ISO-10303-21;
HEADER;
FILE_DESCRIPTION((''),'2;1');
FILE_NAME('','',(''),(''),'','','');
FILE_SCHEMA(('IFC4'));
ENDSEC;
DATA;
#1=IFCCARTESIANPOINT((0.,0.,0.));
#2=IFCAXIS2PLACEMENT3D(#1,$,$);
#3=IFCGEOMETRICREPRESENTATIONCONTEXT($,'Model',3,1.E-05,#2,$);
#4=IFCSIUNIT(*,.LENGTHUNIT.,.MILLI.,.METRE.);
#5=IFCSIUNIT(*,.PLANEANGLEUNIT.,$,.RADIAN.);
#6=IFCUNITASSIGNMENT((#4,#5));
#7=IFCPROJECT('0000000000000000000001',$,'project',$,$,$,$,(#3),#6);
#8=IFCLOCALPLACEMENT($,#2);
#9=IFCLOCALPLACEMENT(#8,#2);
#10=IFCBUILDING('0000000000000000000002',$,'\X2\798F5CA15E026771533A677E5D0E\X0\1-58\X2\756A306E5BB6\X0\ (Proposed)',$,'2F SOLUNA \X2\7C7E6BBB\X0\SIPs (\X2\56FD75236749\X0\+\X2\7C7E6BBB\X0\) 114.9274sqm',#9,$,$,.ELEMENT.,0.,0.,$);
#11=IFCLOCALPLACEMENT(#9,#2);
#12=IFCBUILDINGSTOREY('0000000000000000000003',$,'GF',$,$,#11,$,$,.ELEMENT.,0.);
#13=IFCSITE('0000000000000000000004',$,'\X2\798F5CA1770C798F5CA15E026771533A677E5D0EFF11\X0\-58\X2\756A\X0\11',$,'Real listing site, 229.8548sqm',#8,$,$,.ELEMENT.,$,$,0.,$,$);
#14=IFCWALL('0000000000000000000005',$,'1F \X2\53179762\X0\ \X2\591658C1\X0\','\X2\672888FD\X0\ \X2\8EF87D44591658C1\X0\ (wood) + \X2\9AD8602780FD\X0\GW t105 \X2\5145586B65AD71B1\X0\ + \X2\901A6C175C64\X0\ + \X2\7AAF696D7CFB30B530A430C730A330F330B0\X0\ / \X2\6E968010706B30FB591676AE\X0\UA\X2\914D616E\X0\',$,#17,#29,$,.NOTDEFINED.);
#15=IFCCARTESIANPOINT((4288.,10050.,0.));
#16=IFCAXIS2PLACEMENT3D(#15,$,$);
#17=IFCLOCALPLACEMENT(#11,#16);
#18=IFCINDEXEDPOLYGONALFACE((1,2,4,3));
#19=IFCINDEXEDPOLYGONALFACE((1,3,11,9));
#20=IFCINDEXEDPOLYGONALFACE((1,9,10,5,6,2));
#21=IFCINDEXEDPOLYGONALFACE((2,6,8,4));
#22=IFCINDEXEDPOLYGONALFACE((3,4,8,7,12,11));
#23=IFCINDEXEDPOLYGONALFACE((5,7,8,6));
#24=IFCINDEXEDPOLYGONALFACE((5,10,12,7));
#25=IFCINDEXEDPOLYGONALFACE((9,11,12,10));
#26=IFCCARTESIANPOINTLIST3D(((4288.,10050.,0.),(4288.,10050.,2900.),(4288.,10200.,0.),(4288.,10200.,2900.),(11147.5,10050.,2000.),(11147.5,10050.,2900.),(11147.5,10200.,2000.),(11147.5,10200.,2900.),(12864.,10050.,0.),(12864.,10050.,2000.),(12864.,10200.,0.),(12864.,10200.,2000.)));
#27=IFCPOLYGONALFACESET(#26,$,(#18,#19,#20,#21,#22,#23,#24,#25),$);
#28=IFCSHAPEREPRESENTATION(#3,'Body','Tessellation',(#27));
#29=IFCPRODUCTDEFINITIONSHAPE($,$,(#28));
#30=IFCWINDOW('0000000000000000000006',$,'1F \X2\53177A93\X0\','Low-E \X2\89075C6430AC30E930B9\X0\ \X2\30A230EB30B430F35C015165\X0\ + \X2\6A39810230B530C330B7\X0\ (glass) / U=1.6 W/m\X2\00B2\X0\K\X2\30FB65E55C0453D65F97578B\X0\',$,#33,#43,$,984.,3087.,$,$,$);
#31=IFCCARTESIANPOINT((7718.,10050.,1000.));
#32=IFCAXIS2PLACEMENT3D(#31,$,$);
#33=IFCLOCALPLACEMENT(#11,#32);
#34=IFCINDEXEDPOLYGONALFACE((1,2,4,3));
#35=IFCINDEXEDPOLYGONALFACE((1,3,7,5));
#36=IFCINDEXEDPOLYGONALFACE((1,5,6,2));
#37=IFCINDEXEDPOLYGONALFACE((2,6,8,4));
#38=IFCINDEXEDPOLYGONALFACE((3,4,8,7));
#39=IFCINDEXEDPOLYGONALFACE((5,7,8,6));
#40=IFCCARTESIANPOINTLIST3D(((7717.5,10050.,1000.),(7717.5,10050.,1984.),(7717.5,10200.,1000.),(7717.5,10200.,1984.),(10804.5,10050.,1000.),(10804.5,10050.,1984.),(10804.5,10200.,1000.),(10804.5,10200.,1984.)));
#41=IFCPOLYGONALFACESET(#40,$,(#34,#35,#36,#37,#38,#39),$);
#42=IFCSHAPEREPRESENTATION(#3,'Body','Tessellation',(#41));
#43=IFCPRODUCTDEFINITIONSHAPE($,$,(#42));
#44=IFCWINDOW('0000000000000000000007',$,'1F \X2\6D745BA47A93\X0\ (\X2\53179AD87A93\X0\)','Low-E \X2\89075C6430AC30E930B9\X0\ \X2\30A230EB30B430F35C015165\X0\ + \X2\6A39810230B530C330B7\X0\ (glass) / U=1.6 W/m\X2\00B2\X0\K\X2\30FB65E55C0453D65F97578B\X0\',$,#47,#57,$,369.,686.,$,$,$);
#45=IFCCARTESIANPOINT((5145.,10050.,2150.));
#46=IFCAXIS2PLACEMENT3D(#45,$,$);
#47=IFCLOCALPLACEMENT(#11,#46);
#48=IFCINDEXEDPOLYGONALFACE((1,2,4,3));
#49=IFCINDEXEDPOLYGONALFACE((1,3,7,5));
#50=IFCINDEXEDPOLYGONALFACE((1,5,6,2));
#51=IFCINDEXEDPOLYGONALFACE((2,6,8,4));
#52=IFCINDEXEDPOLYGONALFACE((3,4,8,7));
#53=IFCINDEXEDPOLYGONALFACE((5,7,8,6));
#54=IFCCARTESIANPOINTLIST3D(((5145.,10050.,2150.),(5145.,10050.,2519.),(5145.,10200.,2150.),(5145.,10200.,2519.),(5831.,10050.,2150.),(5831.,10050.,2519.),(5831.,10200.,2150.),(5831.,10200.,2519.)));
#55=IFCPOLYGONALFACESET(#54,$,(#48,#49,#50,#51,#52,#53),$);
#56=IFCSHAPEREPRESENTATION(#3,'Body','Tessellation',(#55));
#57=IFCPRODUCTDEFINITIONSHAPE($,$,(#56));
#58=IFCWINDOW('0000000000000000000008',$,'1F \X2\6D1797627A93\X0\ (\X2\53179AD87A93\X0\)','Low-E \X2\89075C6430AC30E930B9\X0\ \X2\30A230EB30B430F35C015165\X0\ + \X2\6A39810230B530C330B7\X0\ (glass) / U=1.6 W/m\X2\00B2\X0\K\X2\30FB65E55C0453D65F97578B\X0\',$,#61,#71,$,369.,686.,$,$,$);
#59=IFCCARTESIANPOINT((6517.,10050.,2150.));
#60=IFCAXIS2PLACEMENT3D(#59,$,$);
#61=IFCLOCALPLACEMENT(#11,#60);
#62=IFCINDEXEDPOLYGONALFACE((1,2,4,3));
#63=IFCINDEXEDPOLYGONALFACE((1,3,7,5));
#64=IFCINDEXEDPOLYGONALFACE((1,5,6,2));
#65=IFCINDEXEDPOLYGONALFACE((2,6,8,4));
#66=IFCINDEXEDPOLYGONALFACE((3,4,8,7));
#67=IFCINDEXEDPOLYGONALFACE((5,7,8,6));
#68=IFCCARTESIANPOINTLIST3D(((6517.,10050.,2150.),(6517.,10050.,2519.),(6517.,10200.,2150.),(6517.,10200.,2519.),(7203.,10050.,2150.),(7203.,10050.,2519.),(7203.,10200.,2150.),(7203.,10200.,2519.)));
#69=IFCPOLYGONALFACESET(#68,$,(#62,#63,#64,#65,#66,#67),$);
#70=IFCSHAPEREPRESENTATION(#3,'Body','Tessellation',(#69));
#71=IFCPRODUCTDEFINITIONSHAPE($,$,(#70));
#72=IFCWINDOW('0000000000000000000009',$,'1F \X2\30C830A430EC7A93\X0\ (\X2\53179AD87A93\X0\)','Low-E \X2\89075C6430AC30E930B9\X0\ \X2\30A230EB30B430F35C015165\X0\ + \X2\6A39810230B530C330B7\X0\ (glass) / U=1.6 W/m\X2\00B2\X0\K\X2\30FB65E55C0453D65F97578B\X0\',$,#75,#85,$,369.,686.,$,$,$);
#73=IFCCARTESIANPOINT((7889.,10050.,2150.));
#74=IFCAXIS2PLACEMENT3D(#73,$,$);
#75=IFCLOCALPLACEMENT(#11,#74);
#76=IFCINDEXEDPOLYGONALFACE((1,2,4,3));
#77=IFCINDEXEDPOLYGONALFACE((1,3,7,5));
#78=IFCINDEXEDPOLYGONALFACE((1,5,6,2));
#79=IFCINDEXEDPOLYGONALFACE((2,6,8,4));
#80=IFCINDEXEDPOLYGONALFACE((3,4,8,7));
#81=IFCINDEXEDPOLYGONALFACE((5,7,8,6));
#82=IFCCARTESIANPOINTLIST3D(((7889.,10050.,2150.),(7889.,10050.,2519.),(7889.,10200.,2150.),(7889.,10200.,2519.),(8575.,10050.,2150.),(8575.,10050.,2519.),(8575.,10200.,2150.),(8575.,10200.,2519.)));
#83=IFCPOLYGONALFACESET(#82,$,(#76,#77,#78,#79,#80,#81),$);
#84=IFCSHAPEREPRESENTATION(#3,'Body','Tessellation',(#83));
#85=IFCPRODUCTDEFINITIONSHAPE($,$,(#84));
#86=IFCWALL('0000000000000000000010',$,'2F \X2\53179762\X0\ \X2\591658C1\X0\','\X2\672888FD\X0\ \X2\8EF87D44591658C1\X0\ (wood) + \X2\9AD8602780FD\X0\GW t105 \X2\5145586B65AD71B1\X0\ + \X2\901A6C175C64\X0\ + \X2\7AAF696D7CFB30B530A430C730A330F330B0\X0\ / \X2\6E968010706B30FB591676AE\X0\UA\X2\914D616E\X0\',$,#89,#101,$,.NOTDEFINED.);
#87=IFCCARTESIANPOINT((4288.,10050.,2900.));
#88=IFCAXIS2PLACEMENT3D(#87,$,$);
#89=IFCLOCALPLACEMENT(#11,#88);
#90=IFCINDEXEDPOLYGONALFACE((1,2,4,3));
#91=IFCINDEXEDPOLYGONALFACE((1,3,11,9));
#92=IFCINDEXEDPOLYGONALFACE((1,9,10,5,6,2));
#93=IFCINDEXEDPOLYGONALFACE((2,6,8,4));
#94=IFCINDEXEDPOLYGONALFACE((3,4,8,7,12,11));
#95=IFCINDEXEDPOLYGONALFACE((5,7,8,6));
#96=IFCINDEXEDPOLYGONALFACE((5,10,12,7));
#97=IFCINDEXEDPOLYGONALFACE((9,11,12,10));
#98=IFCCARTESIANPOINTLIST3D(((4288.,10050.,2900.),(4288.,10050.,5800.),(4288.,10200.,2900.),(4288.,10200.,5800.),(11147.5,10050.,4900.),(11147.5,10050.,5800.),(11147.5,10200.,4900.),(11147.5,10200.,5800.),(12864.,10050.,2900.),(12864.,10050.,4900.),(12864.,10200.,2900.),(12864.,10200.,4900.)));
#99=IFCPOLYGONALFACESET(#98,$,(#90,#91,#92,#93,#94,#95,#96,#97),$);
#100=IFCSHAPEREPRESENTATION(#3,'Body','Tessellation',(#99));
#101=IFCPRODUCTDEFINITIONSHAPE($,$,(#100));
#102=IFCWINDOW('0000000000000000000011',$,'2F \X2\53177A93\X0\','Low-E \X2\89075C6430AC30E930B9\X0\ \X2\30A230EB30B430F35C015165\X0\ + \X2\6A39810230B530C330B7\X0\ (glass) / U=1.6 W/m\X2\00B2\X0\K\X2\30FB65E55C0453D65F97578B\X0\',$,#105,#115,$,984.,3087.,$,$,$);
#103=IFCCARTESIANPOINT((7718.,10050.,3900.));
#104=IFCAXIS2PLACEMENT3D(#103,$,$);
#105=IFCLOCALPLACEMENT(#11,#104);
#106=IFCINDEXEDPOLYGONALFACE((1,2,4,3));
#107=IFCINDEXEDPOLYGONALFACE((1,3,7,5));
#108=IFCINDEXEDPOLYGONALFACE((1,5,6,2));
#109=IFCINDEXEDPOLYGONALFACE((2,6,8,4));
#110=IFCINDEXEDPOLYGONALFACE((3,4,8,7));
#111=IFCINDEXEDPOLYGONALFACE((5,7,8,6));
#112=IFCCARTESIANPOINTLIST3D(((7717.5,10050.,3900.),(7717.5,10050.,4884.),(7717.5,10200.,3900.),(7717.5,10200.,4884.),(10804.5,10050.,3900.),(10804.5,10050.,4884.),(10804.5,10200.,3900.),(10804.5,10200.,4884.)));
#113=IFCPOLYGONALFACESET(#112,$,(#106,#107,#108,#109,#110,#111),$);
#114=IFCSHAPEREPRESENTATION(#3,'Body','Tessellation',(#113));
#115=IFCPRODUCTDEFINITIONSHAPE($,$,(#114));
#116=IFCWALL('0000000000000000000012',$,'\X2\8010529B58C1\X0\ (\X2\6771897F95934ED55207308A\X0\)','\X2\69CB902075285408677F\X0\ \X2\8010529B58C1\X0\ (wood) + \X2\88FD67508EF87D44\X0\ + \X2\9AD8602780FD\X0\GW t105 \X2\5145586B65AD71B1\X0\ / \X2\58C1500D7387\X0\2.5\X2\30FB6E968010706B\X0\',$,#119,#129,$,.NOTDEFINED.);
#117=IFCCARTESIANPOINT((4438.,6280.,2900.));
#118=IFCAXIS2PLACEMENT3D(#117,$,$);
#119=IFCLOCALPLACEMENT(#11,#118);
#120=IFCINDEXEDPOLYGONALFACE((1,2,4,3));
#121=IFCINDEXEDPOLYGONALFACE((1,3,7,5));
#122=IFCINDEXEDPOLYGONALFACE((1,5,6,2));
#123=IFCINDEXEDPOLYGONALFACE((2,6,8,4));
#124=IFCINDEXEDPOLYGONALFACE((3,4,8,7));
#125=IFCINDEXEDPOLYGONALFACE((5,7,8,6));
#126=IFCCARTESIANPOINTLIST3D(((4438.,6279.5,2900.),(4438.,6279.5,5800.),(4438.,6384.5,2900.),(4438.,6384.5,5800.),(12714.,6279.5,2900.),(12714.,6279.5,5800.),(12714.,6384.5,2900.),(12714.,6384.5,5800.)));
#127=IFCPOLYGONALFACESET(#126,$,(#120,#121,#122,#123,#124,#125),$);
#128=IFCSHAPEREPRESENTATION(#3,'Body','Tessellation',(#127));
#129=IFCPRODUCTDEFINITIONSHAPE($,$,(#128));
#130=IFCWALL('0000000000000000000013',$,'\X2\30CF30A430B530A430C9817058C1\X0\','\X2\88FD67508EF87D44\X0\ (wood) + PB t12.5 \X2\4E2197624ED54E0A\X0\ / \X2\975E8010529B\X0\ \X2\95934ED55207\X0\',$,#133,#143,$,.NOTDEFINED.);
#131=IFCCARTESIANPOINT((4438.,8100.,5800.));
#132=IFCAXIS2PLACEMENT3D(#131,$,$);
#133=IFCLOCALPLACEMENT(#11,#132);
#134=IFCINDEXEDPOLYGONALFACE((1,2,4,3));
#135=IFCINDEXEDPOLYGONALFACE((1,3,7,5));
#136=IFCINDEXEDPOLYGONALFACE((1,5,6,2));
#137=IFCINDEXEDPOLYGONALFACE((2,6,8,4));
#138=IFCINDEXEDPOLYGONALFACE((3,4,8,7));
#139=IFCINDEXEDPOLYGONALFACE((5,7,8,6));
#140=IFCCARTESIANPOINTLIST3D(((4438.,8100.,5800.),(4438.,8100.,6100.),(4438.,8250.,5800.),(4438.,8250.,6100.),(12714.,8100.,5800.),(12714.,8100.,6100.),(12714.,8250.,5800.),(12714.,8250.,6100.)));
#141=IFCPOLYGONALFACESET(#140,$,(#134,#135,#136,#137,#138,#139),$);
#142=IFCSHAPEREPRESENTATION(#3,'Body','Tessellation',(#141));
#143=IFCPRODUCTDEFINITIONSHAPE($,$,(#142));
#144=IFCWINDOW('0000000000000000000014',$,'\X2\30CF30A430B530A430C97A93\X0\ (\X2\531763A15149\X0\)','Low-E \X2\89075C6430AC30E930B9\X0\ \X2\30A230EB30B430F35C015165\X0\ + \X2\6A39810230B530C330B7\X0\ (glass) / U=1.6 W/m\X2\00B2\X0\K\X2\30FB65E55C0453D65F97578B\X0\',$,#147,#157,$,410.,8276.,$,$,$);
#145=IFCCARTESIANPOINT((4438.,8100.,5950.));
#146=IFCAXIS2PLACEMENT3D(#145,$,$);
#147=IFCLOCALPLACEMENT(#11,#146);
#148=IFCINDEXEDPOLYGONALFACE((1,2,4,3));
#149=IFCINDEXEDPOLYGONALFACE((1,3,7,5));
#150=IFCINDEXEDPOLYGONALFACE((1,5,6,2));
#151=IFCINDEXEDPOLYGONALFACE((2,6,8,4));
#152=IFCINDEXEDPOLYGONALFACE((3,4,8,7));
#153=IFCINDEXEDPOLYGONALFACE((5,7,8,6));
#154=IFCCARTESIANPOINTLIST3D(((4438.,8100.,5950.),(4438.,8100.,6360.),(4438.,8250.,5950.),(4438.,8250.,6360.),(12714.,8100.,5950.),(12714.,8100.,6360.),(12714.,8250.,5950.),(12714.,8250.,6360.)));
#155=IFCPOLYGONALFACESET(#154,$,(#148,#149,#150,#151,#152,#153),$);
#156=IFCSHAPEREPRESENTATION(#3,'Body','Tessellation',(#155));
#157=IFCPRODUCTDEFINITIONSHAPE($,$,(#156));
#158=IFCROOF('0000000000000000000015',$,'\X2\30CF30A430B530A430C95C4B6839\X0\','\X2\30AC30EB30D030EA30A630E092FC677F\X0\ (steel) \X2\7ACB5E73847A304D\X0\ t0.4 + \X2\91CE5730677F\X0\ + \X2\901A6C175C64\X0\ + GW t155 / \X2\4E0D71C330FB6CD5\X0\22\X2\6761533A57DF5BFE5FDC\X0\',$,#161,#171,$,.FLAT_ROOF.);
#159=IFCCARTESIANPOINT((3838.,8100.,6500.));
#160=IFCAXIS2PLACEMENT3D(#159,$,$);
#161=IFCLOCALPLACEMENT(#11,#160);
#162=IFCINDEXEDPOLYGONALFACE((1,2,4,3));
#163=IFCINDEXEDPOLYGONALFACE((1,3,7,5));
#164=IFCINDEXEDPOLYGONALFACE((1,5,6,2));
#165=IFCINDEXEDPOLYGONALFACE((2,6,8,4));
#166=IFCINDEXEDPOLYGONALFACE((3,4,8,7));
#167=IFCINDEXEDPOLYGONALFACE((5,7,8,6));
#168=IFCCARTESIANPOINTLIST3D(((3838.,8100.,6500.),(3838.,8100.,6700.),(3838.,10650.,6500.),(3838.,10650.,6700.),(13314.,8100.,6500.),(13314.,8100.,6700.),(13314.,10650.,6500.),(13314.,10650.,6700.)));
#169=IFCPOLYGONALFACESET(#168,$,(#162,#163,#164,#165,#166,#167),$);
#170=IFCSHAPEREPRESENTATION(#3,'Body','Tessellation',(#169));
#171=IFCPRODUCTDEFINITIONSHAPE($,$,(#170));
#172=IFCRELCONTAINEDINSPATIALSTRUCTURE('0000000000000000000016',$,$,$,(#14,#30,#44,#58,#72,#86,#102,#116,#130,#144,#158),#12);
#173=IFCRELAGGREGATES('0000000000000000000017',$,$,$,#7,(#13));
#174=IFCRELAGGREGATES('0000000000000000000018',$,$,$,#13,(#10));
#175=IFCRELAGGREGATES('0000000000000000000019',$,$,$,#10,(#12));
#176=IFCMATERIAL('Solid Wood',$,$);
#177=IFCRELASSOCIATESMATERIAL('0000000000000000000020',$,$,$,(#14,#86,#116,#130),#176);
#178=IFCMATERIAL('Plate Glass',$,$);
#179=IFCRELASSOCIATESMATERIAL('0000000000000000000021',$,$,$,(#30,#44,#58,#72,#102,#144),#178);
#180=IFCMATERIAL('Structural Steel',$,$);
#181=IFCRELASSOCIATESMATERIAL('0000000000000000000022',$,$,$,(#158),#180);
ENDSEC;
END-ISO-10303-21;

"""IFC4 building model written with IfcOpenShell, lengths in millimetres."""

from ifc_helpers import new_model, si_unit, frame, frame_2d, origin, place, context, project, spatial, rectangle, extrude, material, element, fill, save


model = new_model("IFC4")

# Units and contexts
model_context = context("Model", 3, precision=1e-05, world=origin())
ifc_project = project(units=[si_unit("LENGTHUNIT", "METRE", prefix="MILLI"), si_unit("PLANEANGLEUNIT", "RADIAN")], contexts=[model_context])

# Site, building, storey
site_placement = place(None, origin())
site = spatial("IfcSite", under=ifc_project, at=site_placement, Name="福岡県福岡市東区松崎１-58番11", ObjectType="Real listing site, 229.8548sqm", CompositionType="ELEMENT", RefElevation=0.0)
building_placement = place(site_placement, origin())
building = spatial("IfcBuilding", under=site, at=building_placement, Name="福岡市東区松崎1-58番の家 (Proposed)", ObjectType="2F SOLUNA 籾殻SIPs (国産杉+籾殻) 114.9274sqm", CompositionType="ELEMENT", ElevationOfRefHeight=0.0, ElevationOfTerrain=0.0)
storey_placement = place(building_placement, origin())
storey = spatial("IfcBuildingStorey", under=building, at=storey_placement, Name="GF", CompositionType="ELEMENT", Elevation=0.0)

# Wall, openings, windows
ifc_material_1 = material(Name="Solid Wood")
wall_1_placement = place(storey_placement, frame((4288.0, 10050.0, 0.0)))
wall_1 = element("IfcWall", 1, at=wall_1_placement, inside=storey, material=ifc_material_1, Name="1F 北面 外壁", Description="木製 軸組外壁 (wood) + 高性能GW t105 充填断熱 + 通気層 + 窯業系サイディング / 準耐火・外皮UA配慮", PredefinedType="NOTDEFINED", context=model_context, shape_type="SweptSolid", body=[
    extrude(rectangle(XDim=8576.0, YDim=150.0, at=frame_2d((4288.0, 75.0))), frame((4288.0, 10050.0, 0.0)), (0.0, 0.0, 1.0), 2900.0),
])
opening_1_placement = place(storey_placement, frame((7718.0, 10050.0, 1000.0)))
opening_1 = element("IfcOpeningElement", 2, at=opening_1_placement, cuts=wall_1, PredefinedType="NOTDEFINED", context=model_context, shape_type="SweptSolid", body=[
    extrude(rectangle(XDim=3087.0, YDim=150.0, at=frame_2d((1543.0, 75.0))), frame((7718.0, 10050.0, 1000.0)), (0.0, 0.0, 1.0), 984.0),
])
opening_2_placement = place(storey_placement, frame((5145.0, 10050.0, 2150.0)))
opening_2 = element("IfcOpeningElement", 3, at=opening_2_placement, cuts=wall_1, PredefinedType="NOTDEFINED", context=model_context, shape_type="SweptSolid", body=[
    extrude(rectangle(XDim=686.0, YDim=150.0, at=frame_2d((343.0, 75.0))), frame((5145.0, 10050.0, 2150.0)), (0.0, 0.0, 1.0), 369.0),
])
opening_3_placement = place(storey_placement, frame((6517.0, 10050.0, 2150.0)))
opening_3 = element("IfcOpeningElement", 4, at=opening_3_placement, cuts=wall_1, PredefinedType="NOTDEFINED", context=model_context, shape_type="SweptSolid", body=[
    extrude(rectangle(XDim=686.0, YDim=150.0, at=frame_2d((343.0, 75.0))), frame((6517.0, 10050.0, 2150.0)), (0.0, 0.0, 1.0), 369.0),
])
opening_4_placement = place(storey_placement, frame((7889.0, 10050.0, 2150.0)))
opening_4 = element("IfcOpeningElement", 5, at=opening_4_placement, cuts=wall_1, PredefinedType="NOTDEFINED", context=model_context, shape_type="SweptSolid", body=[
    extrude(rectangle(XDim=686.0, YDim=150.0, at=frame_2d((343.0, 75.0))), frame((7889.0, 10050.0, 2150.0)), (0.0, 0.0, 1.0), 369.0),
])
ifc_material_2 = material(Name="Plate Glass")
window_1_placement = place(storey_placement, frame((7718.0, 10050.0, 1000.0)))
window_1 = element("IfcWindow", 6, at=window_1_placement, inside=storey, material=ifc_material_2, Name="1F 北窓", Description="Low-E 複層ガラス アルゴン封入 + 樹脂サッシ (glass) / U=1.6 W/m²K・日射取得型", OverallHeight=984.0, OverallWidth=3087.0, context=model_context, shape_type="SweptSolid", body=[
    extrude(rectangle(XDim=3087.0, YDim=150.0, at=frame_2d((1543.0, 75.0))), frame((7718.0, 10050.0, 1000.0)), (0.0, 0.0, 1.0), 984.0),
])
fill(opening_1, window_1)
window_2_placement = place(storey_placement, frame((5145.0, 10050.0, 2150.0)))
window_2 = element("IfcWindow", 7, at=window_2_placement, inside=storey, material=ifc_material_2, Name="1F 浴室窓 (北高窓)", Description="Low-E 複層ガラス アルゴン封入 + 樹脂サッシ (glass) / U=1.6 W/m²K・日射取得型", OverallHeight=369.0, OverallWidth=686.0, context=model_context, shape_type="SweptSolid", body=[
    extrude(rectangle(XDim=686.0, YDim=150.0, at=frame_2d((343.0, 75.0))), frame((5145.0, 10050.0, 2150.0)), (0.0, 0.0, 1.0), 369.0),
])
fill(opening_2, window_2)
window_3_placement = place(storey_placement, frame((6517.0, 10050.0, 2150.0)))
window_3 = element("IfcWindow", 8, at=window_3_placement, inside=storey, material=ifc_material_2, Name="1F 洗面窓 (北高窓)", Description="Low-E 複層ガラス アルゴン封入 + 樹脂サッシ (glass) / U=1.6 W/m²K・日射取得型", OverallHeight=369.0, OverallWidth=686.0, context=model_context, shape_type="SweptSolid", body=[
    extrude(rectangle(XDim=686.0, YDim=150.0, at=frame_2d((343.0, 75.0))), frame((6517.0, 10050.0, 2150.0)), (0.0, 0.0, 1.0), 369.0),
])
fill(opening_3, window_3)
window_4_placement = place(storey_placement, frame((7889.0, 10050.0, 2150.0)))
window_4 = element("IfcWindow", 9, at=window_4_placement, inside=storey, material=ifc_material_2, Name="1F トイレ窓 (北高窓)", Description="Low-E 複層ガラス アルゴン封入 + 樹脂サッシ (glass) / U=1.6 W/m²K・日射取得型", OverallHeight=369.0, OverallWidth=686.0, context=model_context, shape_type="SweptSolid", body=[
    extrude(rectangle(XDim=686.0, YDim=150.0, at=frame_2d((343.0, 75.0))), frame((7889.0, 10050.0, 2150.0)), (0.0, 0.0, 1.0), 369.0),
])
fill(opening_4, window_4)

# Wall, opening, window
wall_2_placement = place(storey_placement, frame((4288.0, 10050.0, 2900.0)))
wall_2 = element("IfcWall", 10, at=wall_2_placement, inside=storey, material=ifc_material_1, Name="2F 北面 外壁", Description="木製 軸組外壁 (wood) + 高性能GW t105 充填断熱 + 通気層 + 窯業系サイディング / 準耐火・外皮UA配慮", PredefinedType="NOTDEFINED", context=model_context, shape_type="SweptSolid", body=[
    extrude(rectangle(XDim=8576.0, YDim=150.0, at=frame_2d((4288.0, 75.0))), frame((4288.0, 10050.0, 2900.0)), (0.0, 0.0, 1.0), 2900.0),
])
opening_5_placement = place(storey_placement, frame((7718.0, 10050.0, 3900.0)))
opening_5 = element("IfcOpeningElement", 11, at=opening_5_placement, cuts=wall_2, PredefinedType="NOTDEFINED", context=model_context, shape_type="SweptSolid", body=[
    extrude(rectangle(XDim=3087.0, YDim=150.0, at=frame_2d((1543.0, 75.0))), frame((7718.0, 10050.0, 3900.0)), (0.0, 0.0, 1.0), 984.0),
])
window_5_placement = place(storey_placement, frame((7718.0, 10050.0, 3900.0)))
window_5 = element("IfcWindow", 12, at=window_5_placement, inside=storey, material=ifc_material_2, Name="2F 北窓", Description="Low-E 複層ガラス アルゴン封入 + 樹脂サッシ (glass) / U=1.6 W/m²K・日射取得型", OverallHeight=984.0, OverallWidth=3087.0, context=model_context, shape_type="SweptSolid", body=[
    extrude(rectangle(XDim=3087.0, YDim=150.0, at=frame_2d((1543.0, 75.0))), frame((7718.0, 10050.0, 3900.0)), (0.0, 0.0, 1.0), 984.0),
])
fill(opening_5, window_5)

# Wall
wall_3_placement = place(storey_placement, frame((4438.0, 6280.0, 2900.0)))
element("IfcWall", 13, at=wall_3_placement, inside=storey, material=ifc_material_1, Name="耐力壁 (東西間仕切り)", Description="構造用合板 耐力壁 (wood) + 製材軸組 + 高性能GW t105 充填断熱 / 壁倍率2.5・準耐火", PredefinedType="NOTDEFINED", context=model_context, shape_type="SweptSolid", body=[
    extrude(rectangle(XDim=8276.0, YDim=105.0, at=frame_2d((4138.0, 52.0))), frame((4438.0, 6280.0, 2900.0)), (0.0, 0.0, 1.0), 2900.0),
])

# Wall, opening, window
wall_4_placement = place(storey_placement, frame((4438.0, 8100.0, 5800.0)))
wall_4 = element("IfcWall", 14, at=wall_4_placement, inside=storey, material=ifc_material_1, Name="ハイサイド腰壁", Description="製材軸組 (wood) + PB t12.5 両面仕上 / 非耐力 間仕切", PredefinedType="NOTDEFINED", context=model_context, shape_type="SweptSolid", body=[
    extrude(rectangle(XDim=8276.0, YDim=150.0, at=frame_2d((4138.0, 75.0))), frame((4438.0, 8100.0, 5800.0)), (0.0, 0.0, 1.0), 700.0),
])
opening_6_placement = place(storey_placement, frame((4438.0, 8100.0, 5950.0)))
opening_6 = element("IfcOpeningElement", 15, at=opening_6_placement, cuts=wall_4, PredefinedType="NOTDEFINED", context=model_context, shape_type="SweptSolid", body=[
    extrude(rectangle(XDim=8276.0, YDim=150.0, at=frame_2d((4138.0, 75.0))), frame((4438.0, 8100.0, 5950.0)), (0.0, 0.0, 1.0), 410.0),
])
window_6_placement = place(storey_placement, frame((4438.0, 8100.0, 5950.0)))
window_6 = element("IfcWindow", 16, at=window_6_placement, inside=storey, material=ifc_material_2, Name="ハイサイド窓 (北採光)", Description="Low-E 複層ガラス アルゴン封入 + 樹脂サッシ (glass) / U=1.6 W/m²K・日射取得型", OverallHeight=410.0, OverallWidth=8276.0, context=model_context, shape_type="SweptSolid", body=[
    extrude(rectangle(XDim=8276.0, YDim=150.0, at=frame_2d((4138.0, 75.0))), frame((4438.0, 8100.0, 5950.0)), (0.0, 0.0, 1.0), 410.0),
])
fill(opening_6, window_6)

# Roof
ifc_material_3 = material(Name="Structural Steel")
roof_placement = place(storey_placement, frame((3838.0, 8100.0, 6500.0)))
element("IfcRoof", 17, at=roof_placement, inside=storey, material=ifc_material_3, Name="ハイサイド屋根", Description="ガルバリウム鋼板 (steel) 立平葺き t0.4 + 野地板 + 通気層 + GW t155 / 不燃・法22条区域対応", PredefinedType="FLAT_ROOF", context=model_context, shape_type="SweptSolid", body=[
    extrude(rectangle(XDim=9476.0, YDim=2550.0, at=frame_2d((4738.0, 1275.0))), frame((3838.0, 8100.0, 6500.0)), (0.0, 0.0, 1.0), 200.0),
])

save(model, "model.ifc")
